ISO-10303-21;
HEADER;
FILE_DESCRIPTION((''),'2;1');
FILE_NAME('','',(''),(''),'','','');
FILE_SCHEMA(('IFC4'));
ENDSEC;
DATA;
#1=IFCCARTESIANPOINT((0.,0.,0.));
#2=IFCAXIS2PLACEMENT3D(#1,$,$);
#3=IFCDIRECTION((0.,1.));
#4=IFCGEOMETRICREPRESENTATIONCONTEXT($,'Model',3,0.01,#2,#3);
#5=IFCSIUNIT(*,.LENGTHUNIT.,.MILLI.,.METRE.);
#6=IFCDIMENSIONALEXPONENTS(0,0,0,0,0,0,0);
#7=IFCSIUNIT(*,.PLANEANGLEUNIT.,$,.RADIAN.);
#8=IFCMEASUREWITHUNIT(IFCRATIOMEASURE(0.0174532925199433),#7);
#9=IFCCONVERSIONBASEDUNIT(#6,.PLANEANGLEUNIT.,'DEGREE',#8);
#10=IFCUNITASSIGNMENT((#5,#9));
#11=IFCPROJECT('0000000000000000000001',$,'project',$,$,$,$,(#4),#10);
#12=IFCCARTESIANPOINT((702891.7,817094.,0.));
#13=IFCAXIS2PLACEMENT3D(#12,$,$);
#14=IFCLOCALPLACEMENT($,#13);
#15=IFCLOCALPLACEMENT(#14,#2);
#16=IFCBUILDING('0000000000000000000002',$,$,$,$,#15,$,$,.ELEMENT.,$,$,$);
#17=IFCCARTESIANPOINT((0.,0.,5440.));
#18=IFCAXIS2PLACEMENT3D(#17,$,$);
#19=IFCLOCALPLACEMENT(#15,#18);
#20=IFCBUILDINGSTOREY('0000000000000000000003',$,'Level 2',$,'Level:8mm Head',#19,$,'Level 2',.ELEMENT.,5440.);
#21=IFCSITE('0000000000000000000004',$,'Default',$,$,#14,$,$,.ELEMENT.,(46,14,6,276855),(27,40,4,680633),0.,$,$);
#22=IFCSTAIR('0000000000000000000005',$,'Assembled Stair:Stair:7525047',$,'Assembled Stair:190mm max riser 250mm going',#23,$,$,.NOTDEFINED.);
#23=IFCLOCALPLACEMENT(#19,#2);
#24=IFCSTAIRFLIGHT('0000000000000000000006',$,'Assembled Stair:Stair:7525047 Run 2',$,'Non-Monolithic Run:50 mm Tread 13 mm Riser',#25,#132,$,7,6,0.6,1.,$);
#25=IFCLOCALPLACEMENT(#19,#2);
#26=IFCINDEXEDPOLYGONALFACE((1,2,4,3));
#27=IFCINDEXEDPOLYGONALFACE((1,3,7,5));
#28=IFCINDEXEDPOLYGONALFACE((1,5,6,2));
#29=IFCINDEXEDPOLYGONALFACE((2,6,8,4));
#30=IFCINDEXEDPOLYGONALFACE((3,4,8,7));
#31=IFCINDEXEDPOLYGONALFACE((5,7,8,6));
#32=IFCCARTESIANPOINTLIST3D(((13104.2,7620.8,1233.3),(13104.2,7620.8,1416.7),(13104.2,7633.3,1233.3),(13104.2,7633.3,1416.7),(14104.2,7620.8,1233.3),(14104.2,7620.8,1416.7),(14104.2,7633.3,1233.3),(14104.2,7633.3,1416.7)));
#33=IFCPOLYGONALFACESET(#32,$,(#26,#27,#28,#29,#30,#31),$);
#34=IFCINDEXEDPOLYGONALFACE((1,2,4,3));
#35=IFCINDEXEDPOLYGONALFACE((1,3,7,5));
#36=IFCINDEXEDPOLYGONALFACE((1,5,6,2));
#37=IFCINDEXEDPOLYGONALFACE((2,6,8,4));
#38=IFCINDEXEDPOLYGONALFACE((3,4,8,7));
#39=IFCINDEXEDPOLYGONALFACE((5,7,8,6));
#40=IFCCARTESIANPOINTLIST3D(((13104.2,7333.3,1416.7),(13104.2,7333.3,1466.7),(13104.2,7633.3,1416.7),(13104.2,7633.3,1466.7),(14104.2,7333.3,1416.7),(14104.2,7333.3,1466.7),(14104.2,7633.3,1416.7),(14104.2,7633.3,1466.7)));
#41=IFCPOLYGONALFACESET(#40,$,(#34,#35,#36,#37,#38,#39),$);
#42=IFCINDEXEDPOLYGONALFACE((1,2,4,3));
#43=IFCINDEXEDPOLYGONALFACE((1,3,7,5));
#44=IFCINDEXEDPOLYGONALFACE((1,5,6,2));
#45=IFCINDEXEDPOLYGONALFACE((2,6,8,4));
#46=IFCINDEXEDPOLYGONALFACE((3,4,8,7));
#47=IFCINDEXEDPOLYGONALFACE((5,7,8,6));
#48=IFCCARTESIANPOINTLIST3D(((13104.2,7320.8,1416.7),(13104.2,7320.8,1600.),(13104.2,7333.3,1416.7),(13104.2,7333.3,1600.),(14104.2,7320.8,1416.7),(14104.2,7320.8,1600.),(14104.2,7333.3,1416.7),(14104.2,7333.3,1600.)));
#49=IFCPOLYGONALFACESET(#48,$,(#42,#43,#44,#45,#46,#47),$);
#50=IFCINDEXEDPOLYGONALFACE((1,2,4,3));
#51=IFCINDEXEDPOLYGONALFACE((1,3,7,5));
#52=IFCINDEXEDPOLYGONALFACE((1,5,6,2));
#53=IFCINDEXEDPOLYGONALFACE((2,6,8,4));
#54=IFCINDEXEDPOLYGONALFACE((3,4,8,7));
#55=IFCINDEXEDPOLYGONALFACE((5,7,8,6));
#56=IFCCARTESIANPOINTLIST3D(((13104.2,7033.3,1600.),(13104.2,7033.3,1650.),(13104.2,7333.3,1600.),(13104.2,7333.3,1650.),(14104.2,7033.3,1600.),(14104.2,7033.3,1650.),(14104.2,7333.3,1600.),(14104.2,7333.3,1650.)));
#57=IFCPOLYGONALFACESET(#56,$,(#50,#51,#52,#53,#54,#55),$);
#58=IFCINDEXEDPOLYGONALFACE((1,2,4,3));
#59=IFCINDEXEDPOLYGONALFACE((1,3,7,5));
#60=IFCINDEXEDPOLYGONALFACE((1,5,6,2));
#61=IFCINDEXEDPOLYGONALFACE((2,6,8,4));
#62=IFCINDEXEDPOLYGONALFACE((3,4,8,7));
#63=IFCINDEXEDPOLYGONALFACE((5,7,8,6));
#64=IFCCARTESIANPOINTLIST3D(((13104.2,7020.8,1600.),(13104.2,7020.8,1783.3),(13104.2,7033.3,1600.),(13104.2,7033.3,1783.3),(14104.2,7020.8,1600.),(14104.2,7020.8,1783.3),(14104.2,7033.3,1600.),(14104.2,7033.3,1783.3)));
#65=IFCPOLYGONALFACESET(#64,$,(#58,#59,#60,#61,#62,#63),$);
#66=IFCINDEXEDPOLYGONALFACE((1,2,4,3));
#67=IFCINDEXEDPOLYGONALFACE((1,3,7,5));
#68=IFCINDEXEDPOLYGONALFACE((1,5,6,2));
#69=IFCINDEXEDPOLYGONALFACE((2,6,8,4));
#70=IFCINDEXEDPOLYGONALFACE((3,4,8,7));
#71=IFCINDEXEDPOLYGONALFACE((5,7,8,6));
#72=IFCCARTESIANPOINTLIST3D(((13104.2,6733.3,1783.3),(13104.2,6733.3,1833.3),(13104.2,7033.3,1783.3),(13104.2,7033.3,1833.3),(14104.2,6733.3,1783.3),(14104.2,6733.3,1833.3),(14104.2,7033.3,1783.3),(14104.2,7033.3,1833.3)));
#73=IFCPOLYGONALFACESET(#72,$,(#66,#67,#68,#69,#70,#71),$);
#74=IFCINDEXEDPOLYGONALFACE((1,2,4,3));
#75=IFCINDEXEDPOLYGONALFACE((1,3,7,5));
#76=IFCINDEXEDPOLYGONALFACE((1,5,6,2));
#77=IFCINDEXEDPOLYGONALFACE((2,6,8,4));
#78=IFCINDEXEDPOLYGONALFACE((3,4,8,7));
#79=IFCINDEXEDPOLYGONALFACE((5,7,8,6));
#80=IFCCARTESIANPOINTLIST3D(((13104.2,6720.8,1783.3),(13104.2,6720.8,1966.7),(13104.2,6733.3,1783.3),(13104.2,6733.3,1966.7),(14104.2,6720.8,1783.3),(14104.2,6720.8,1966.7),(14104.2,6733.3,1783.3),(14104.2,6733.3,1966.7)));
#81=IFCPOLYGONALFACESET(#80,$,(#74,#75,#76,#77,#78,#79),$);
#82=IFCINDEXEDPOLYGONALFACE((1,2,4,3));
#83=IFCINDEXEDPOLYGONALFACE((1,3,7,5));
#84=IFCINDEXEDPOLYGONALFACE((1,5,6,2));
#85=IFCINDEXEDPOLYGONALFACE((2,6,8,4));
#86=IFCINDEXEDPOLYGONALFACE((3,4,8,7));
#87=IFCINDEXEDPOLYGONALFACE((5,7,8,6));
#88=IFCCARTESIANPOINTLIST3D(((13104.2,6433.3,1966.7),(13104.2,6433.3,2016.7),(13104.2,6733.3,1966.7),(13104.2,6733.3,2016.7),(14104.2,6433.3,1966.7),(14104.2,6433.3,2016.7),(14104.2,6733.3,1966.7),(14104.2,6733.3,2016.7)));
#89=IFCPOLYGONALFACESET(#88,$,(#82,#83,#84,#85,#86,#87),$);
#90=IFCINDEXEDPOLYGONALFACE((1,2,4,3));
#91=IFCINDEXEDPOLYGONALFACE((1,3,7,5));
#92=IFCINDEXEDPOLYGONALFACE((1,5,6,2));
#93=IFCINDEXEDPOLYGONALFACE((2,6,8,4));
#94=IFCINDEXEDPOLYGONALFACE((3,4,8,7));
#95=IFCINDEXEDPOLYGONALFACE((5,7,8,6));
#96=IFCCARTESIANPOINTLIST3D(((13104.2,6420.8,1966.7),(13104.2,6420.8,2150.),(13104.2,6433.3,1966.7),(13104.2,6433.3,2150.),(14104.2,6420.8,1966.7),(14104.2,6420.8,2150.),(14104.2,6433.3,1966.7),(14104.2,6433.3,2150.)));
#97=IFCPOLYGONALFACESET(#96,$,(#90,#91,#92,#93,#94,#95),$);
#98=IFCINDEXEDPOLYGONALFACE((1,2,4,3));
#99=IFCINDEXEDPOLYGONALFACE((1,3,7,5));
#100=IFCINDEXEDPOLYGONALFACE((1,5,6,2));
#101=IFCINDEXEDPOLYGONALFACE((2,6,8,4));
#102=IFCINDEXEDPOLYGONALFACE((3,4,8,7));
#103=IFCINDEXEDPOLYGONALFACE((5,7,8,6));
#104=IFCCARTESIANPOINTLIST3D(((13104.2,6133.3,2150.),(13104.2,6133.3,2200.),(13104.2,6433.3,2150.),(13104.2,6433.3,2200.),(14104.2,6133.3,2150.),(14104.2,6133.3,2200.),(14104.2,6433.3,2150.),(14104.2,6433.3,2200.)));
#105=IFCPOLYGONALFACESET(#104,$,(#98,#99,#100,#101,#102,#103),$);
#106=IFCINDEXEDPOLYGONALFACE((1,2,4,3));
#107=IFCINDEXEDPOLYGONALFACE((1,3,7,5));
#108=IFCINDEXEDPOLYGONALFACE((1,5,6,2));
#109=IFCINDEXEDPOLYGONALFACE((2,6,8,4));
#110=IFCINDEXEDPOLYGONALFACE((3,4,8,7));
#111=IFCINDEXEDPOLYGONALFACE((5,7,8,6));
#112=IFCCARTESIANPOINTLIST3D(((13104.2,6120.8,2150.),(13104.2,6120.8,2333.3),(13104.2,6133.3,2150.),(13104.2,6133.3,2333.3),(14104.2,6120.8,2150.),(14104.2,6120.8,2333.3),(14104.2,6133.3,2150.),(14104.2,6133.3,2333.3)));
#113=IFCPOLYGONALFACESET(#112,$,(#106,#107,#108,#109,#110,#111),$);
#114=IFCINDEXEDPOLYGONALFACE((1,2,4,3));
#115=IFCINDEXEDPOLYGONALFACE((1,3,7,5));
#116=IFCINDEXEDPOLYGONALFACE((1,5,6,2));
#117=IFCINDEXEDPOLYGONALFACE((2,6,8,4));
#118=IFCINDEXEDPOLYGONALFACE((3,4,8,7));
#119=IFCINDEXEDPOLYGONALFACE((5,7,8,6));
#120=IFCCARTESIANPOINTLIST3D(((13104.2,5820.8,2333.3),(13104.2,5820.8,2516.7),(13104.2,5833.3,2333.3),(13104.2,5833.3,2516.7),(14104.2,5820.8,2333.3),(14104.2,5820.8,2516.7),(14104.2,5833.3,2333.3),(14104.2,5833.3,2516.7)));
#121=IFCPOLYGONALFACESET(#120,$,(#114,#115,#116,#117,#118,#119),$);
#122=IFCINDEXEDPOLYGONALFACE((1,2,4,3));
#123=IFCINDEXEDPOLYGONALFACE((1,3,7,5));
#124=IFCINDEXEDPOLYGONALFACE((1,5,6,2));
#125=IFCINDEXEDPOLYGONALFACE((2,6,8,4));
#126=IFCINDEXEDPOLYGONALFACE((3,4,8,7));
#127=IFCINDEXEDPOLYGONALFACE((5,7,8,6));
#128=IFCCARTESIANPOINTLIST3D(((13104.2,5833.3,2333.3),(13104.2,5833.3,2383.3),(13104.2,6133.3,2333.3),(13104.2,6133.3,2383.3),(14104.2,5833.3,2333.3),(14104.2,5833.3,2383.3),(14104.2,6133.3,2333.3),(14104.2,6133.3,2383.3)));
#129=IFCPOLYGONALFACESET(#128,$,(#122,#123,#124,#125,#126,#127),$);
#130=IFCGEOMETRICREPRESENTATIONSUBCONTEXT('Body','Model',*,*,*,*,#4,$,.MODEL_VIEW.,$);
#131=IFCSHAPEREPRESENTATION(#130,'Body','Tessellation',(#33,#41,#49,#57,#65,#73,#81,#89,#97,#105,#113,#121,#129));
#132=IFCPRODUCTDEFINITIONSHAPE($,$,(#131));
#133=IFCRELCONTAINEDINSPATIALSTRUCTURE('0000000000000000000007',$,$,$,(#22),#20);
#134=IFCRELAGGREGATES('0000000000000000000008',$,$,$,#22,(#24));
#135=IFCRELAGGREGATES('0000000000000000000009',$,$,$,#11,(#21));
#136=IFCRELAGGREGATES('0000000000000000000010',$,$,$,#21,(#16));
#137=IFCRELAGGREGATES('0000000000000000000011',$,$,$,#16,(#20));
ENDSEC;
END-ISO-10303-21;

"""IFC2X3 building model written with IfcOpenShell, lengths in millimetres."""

from ifc_helpers import new_model, entity, si_unit, converted_unit, direction, frame, frame_2d, origin, place, context, subcontext, project, spatial, rectangle, extrude, element, aggregate, save


model = new_model("IFC2X3")

# Units and contexts
model_context = context("Model", 3, precision=0.01, world=origin(), true_north=direction((0.0, 1.0)))
body_context = subcontext(model_context, "Body", "Model", "MODEL_VIEW")
ifc_project = project(units=[si_unit("LENGTHUNIT", "METRE", prefix="MILLI"), converted_unit("PLANEANGLEUNIT", "DEGREE", entity("IfcRatioMeasure", 0.0174532925199433), si_unit("PLANEANGLEUNIT", "RADIAN"), dimensions=[0, 0, 0, 0, 0, 0, 0])], contexts=[model_context])

# Site, building, storey
site_placement = place(None, frame((702891.7, 817094.0, 0.0)))
site = spatial("IfcSite", under=ifc_project, at=site_placement, Name="Default", CompositionType="ELEMENT", RefLatitude=(46, 14, 6, 276855), RefLongitude=(27, 40, 4, 680633), RefElevation=0.0)
building_placement = place(site_placement, origin())
building = spatial("IfcBuilding", under=site, at=building_placement, CompositionType="ELEMENT")
storey_placement = place(building_placement, frame((0.0, 0.0, 5440.0)))
storey = spatial("IfcBuildingStorey", under=building, at=storey_placement, Name="Level 2", ObjectType="Level:8mm Head", LongName="Level 2", CompositionType="ELEMENT", Elevation=5440.0)

# Stair
stair_1_placement = place(storey_placement, origin())
stair_1 = element("IfcStair", 1, at=stair_1_placement, inside=storey, Name="Assembled Stair:Stair:7525047", ObjectType="Assembled Stair:190mm max riser 250mm going", ShapeType="NOTDEFINED")

# Stair flight
stair_flight_1_placement = place(stair_1_placement, origin())
stair_flight_1 = element("IfcStairFlight", 2, at=stair_flight_1_placement, Name="Assembled Stair:Stair:7525047 Run 2", ObjectType="Non-Monolithic Run:50 mm Tread 13 mm Riser", NumberOfRiser=7, NumberOfTreads=6, RiserHeight=0.6, TreadLength=1.0, context=body_context, shape_type="SweptSolid", body=[
    extrude(rectangle(XDim=1000.0, YDim=12.5, at=frame_2d((0.0, 0.0), x_axis=(1.0, 0.0))), frame((13604.2, 7627.1, 1233.3)), (0.0, 0.0, 1.0), 183.3),
    extrude(rectangle(XDim=300.0, YDim=1000.0, at=frame_2d((0.0, 0.0), x_axis=(1.0, 0.0))), frame((13604.2, 7483.3, 1416.7), z_axis=(0.0, 0.0, 1.0), x_axis=(0.0, 1.0, 0.0)), (0.0, 0.0, 1.0), 50.0),
    extrude(rectangle(XDim=1000.0, YDim=12.5, at=frame_2d((0.0, 0.0), x_axis=(1.0, 0.0))), frame((13604.2, 7327.1, 1416.7)), (0.0, 0.0, 1.0), 183.3),
    extrude(rectangle(XDim=300.0, YDim=1000.0, at=frame_2d((0.0, 0.0), x_axis=(1.0, 0.0))), frame((13604.2, 7183.3, 1600.0), z_axis=(0.0, 0.0, 1.0), x_axis=(0.0, 1.0, 0.0)), (0.0, 0.0, 1.0), 50.0),
    extrude(rectangle(XDim=1000.0, YDim=12.5, at=frame_2d((0.0, 0.0), x_axis=(1.0, 0.0))), frame((13604.2, 7027.1, 1600.0)), (0.0, 0.0, 1.0), 183.3),
    extrude(rectangle(XDim=300.0, YDim=1000.0, at=frame_2d((0.0, 0.0), x_axis=(1.0, 0.0))), frame((13604.2, 6883.3, 1783.3), z_axis=(0.0, 0.0, 1.0), x_axis=(0.0, 1.0, 0.0)), (0.0, 0.0, 1.0), 50.0),
    extrude(rectangle(XDim=1000.0, YDim=12.5, at=frame_2d((0.0, 0.0), x_axis=(1.0, 0.0))), frame((13604.2, 6727.1, 1783.3)), (0.0, 0.0, 1.0), 183.3),
    extrude(rectangle(XDim=300.0, YDim=1000.0, at=frame_2d((0.0, 0.0), x_axis=(1.0, 0.0))), frame((13604.2, 6583.3, 1966.7), z_axis=(0.0, 0.0, 1.0), x_axis=(0.0, 1.0, 0.0)), (0.0, 0.0, 1.0), 50.0),
    extrude(rectangle(XDim=1000.0, YDim=12.5, at=frame_2d((0.0, 0.0), x_axis=(1.0, 0.0))), frame((13604.2, 6427.1, 1966.7)), (0.0, 0.0, 1.0), 183.3),
    extrude(rectangle(XDim=300.0, YDim=1000.0, at=frame_2d((0.0, 0.0), x_axis=(1.0, 0.0))), frame((13604.2, 6283.3, 2150.0), z_axis=(0.0, 0.0, 1.0), x_axis=(0.0, 1.0, 0.0)), (0.0, 0.0, 1.0), 50.0),
    extrude(rectangle(XDim=1000.0, YDim=12.5, at=frame_2d((0.0, 0.0), x_axis=(1.0, 0.0))), frame((13604.2, 6127.1, 2150.0)), (0.0, 0.0, 1.0), 183.3),
    extrude(rectangle(XDim=1000.0, YDim=12.5, at=frame_2d((0.0, 0.0), x_axis=(1.0, 0.0))), frame((13604.2, 5827.1, 2333.3)), (0.0, 0.0, 1.0), 183.3),
    extrude(rectangle(XDim=300.0, YDim=1000.0, at=frame_2d((0.0, 0.0), x_axis=(1.0, 0.0))), frame((13604.2, 5983.3, 2333.3), z_axis=(0.0, 0.0, 1.0), x_axis=(0.0, 1.0, 0.0)), (0.0, 0.0, 1.0), 50.0),
])
aggregate(stair_1, [stair_flight_1])

save(model, "model.ifc")
